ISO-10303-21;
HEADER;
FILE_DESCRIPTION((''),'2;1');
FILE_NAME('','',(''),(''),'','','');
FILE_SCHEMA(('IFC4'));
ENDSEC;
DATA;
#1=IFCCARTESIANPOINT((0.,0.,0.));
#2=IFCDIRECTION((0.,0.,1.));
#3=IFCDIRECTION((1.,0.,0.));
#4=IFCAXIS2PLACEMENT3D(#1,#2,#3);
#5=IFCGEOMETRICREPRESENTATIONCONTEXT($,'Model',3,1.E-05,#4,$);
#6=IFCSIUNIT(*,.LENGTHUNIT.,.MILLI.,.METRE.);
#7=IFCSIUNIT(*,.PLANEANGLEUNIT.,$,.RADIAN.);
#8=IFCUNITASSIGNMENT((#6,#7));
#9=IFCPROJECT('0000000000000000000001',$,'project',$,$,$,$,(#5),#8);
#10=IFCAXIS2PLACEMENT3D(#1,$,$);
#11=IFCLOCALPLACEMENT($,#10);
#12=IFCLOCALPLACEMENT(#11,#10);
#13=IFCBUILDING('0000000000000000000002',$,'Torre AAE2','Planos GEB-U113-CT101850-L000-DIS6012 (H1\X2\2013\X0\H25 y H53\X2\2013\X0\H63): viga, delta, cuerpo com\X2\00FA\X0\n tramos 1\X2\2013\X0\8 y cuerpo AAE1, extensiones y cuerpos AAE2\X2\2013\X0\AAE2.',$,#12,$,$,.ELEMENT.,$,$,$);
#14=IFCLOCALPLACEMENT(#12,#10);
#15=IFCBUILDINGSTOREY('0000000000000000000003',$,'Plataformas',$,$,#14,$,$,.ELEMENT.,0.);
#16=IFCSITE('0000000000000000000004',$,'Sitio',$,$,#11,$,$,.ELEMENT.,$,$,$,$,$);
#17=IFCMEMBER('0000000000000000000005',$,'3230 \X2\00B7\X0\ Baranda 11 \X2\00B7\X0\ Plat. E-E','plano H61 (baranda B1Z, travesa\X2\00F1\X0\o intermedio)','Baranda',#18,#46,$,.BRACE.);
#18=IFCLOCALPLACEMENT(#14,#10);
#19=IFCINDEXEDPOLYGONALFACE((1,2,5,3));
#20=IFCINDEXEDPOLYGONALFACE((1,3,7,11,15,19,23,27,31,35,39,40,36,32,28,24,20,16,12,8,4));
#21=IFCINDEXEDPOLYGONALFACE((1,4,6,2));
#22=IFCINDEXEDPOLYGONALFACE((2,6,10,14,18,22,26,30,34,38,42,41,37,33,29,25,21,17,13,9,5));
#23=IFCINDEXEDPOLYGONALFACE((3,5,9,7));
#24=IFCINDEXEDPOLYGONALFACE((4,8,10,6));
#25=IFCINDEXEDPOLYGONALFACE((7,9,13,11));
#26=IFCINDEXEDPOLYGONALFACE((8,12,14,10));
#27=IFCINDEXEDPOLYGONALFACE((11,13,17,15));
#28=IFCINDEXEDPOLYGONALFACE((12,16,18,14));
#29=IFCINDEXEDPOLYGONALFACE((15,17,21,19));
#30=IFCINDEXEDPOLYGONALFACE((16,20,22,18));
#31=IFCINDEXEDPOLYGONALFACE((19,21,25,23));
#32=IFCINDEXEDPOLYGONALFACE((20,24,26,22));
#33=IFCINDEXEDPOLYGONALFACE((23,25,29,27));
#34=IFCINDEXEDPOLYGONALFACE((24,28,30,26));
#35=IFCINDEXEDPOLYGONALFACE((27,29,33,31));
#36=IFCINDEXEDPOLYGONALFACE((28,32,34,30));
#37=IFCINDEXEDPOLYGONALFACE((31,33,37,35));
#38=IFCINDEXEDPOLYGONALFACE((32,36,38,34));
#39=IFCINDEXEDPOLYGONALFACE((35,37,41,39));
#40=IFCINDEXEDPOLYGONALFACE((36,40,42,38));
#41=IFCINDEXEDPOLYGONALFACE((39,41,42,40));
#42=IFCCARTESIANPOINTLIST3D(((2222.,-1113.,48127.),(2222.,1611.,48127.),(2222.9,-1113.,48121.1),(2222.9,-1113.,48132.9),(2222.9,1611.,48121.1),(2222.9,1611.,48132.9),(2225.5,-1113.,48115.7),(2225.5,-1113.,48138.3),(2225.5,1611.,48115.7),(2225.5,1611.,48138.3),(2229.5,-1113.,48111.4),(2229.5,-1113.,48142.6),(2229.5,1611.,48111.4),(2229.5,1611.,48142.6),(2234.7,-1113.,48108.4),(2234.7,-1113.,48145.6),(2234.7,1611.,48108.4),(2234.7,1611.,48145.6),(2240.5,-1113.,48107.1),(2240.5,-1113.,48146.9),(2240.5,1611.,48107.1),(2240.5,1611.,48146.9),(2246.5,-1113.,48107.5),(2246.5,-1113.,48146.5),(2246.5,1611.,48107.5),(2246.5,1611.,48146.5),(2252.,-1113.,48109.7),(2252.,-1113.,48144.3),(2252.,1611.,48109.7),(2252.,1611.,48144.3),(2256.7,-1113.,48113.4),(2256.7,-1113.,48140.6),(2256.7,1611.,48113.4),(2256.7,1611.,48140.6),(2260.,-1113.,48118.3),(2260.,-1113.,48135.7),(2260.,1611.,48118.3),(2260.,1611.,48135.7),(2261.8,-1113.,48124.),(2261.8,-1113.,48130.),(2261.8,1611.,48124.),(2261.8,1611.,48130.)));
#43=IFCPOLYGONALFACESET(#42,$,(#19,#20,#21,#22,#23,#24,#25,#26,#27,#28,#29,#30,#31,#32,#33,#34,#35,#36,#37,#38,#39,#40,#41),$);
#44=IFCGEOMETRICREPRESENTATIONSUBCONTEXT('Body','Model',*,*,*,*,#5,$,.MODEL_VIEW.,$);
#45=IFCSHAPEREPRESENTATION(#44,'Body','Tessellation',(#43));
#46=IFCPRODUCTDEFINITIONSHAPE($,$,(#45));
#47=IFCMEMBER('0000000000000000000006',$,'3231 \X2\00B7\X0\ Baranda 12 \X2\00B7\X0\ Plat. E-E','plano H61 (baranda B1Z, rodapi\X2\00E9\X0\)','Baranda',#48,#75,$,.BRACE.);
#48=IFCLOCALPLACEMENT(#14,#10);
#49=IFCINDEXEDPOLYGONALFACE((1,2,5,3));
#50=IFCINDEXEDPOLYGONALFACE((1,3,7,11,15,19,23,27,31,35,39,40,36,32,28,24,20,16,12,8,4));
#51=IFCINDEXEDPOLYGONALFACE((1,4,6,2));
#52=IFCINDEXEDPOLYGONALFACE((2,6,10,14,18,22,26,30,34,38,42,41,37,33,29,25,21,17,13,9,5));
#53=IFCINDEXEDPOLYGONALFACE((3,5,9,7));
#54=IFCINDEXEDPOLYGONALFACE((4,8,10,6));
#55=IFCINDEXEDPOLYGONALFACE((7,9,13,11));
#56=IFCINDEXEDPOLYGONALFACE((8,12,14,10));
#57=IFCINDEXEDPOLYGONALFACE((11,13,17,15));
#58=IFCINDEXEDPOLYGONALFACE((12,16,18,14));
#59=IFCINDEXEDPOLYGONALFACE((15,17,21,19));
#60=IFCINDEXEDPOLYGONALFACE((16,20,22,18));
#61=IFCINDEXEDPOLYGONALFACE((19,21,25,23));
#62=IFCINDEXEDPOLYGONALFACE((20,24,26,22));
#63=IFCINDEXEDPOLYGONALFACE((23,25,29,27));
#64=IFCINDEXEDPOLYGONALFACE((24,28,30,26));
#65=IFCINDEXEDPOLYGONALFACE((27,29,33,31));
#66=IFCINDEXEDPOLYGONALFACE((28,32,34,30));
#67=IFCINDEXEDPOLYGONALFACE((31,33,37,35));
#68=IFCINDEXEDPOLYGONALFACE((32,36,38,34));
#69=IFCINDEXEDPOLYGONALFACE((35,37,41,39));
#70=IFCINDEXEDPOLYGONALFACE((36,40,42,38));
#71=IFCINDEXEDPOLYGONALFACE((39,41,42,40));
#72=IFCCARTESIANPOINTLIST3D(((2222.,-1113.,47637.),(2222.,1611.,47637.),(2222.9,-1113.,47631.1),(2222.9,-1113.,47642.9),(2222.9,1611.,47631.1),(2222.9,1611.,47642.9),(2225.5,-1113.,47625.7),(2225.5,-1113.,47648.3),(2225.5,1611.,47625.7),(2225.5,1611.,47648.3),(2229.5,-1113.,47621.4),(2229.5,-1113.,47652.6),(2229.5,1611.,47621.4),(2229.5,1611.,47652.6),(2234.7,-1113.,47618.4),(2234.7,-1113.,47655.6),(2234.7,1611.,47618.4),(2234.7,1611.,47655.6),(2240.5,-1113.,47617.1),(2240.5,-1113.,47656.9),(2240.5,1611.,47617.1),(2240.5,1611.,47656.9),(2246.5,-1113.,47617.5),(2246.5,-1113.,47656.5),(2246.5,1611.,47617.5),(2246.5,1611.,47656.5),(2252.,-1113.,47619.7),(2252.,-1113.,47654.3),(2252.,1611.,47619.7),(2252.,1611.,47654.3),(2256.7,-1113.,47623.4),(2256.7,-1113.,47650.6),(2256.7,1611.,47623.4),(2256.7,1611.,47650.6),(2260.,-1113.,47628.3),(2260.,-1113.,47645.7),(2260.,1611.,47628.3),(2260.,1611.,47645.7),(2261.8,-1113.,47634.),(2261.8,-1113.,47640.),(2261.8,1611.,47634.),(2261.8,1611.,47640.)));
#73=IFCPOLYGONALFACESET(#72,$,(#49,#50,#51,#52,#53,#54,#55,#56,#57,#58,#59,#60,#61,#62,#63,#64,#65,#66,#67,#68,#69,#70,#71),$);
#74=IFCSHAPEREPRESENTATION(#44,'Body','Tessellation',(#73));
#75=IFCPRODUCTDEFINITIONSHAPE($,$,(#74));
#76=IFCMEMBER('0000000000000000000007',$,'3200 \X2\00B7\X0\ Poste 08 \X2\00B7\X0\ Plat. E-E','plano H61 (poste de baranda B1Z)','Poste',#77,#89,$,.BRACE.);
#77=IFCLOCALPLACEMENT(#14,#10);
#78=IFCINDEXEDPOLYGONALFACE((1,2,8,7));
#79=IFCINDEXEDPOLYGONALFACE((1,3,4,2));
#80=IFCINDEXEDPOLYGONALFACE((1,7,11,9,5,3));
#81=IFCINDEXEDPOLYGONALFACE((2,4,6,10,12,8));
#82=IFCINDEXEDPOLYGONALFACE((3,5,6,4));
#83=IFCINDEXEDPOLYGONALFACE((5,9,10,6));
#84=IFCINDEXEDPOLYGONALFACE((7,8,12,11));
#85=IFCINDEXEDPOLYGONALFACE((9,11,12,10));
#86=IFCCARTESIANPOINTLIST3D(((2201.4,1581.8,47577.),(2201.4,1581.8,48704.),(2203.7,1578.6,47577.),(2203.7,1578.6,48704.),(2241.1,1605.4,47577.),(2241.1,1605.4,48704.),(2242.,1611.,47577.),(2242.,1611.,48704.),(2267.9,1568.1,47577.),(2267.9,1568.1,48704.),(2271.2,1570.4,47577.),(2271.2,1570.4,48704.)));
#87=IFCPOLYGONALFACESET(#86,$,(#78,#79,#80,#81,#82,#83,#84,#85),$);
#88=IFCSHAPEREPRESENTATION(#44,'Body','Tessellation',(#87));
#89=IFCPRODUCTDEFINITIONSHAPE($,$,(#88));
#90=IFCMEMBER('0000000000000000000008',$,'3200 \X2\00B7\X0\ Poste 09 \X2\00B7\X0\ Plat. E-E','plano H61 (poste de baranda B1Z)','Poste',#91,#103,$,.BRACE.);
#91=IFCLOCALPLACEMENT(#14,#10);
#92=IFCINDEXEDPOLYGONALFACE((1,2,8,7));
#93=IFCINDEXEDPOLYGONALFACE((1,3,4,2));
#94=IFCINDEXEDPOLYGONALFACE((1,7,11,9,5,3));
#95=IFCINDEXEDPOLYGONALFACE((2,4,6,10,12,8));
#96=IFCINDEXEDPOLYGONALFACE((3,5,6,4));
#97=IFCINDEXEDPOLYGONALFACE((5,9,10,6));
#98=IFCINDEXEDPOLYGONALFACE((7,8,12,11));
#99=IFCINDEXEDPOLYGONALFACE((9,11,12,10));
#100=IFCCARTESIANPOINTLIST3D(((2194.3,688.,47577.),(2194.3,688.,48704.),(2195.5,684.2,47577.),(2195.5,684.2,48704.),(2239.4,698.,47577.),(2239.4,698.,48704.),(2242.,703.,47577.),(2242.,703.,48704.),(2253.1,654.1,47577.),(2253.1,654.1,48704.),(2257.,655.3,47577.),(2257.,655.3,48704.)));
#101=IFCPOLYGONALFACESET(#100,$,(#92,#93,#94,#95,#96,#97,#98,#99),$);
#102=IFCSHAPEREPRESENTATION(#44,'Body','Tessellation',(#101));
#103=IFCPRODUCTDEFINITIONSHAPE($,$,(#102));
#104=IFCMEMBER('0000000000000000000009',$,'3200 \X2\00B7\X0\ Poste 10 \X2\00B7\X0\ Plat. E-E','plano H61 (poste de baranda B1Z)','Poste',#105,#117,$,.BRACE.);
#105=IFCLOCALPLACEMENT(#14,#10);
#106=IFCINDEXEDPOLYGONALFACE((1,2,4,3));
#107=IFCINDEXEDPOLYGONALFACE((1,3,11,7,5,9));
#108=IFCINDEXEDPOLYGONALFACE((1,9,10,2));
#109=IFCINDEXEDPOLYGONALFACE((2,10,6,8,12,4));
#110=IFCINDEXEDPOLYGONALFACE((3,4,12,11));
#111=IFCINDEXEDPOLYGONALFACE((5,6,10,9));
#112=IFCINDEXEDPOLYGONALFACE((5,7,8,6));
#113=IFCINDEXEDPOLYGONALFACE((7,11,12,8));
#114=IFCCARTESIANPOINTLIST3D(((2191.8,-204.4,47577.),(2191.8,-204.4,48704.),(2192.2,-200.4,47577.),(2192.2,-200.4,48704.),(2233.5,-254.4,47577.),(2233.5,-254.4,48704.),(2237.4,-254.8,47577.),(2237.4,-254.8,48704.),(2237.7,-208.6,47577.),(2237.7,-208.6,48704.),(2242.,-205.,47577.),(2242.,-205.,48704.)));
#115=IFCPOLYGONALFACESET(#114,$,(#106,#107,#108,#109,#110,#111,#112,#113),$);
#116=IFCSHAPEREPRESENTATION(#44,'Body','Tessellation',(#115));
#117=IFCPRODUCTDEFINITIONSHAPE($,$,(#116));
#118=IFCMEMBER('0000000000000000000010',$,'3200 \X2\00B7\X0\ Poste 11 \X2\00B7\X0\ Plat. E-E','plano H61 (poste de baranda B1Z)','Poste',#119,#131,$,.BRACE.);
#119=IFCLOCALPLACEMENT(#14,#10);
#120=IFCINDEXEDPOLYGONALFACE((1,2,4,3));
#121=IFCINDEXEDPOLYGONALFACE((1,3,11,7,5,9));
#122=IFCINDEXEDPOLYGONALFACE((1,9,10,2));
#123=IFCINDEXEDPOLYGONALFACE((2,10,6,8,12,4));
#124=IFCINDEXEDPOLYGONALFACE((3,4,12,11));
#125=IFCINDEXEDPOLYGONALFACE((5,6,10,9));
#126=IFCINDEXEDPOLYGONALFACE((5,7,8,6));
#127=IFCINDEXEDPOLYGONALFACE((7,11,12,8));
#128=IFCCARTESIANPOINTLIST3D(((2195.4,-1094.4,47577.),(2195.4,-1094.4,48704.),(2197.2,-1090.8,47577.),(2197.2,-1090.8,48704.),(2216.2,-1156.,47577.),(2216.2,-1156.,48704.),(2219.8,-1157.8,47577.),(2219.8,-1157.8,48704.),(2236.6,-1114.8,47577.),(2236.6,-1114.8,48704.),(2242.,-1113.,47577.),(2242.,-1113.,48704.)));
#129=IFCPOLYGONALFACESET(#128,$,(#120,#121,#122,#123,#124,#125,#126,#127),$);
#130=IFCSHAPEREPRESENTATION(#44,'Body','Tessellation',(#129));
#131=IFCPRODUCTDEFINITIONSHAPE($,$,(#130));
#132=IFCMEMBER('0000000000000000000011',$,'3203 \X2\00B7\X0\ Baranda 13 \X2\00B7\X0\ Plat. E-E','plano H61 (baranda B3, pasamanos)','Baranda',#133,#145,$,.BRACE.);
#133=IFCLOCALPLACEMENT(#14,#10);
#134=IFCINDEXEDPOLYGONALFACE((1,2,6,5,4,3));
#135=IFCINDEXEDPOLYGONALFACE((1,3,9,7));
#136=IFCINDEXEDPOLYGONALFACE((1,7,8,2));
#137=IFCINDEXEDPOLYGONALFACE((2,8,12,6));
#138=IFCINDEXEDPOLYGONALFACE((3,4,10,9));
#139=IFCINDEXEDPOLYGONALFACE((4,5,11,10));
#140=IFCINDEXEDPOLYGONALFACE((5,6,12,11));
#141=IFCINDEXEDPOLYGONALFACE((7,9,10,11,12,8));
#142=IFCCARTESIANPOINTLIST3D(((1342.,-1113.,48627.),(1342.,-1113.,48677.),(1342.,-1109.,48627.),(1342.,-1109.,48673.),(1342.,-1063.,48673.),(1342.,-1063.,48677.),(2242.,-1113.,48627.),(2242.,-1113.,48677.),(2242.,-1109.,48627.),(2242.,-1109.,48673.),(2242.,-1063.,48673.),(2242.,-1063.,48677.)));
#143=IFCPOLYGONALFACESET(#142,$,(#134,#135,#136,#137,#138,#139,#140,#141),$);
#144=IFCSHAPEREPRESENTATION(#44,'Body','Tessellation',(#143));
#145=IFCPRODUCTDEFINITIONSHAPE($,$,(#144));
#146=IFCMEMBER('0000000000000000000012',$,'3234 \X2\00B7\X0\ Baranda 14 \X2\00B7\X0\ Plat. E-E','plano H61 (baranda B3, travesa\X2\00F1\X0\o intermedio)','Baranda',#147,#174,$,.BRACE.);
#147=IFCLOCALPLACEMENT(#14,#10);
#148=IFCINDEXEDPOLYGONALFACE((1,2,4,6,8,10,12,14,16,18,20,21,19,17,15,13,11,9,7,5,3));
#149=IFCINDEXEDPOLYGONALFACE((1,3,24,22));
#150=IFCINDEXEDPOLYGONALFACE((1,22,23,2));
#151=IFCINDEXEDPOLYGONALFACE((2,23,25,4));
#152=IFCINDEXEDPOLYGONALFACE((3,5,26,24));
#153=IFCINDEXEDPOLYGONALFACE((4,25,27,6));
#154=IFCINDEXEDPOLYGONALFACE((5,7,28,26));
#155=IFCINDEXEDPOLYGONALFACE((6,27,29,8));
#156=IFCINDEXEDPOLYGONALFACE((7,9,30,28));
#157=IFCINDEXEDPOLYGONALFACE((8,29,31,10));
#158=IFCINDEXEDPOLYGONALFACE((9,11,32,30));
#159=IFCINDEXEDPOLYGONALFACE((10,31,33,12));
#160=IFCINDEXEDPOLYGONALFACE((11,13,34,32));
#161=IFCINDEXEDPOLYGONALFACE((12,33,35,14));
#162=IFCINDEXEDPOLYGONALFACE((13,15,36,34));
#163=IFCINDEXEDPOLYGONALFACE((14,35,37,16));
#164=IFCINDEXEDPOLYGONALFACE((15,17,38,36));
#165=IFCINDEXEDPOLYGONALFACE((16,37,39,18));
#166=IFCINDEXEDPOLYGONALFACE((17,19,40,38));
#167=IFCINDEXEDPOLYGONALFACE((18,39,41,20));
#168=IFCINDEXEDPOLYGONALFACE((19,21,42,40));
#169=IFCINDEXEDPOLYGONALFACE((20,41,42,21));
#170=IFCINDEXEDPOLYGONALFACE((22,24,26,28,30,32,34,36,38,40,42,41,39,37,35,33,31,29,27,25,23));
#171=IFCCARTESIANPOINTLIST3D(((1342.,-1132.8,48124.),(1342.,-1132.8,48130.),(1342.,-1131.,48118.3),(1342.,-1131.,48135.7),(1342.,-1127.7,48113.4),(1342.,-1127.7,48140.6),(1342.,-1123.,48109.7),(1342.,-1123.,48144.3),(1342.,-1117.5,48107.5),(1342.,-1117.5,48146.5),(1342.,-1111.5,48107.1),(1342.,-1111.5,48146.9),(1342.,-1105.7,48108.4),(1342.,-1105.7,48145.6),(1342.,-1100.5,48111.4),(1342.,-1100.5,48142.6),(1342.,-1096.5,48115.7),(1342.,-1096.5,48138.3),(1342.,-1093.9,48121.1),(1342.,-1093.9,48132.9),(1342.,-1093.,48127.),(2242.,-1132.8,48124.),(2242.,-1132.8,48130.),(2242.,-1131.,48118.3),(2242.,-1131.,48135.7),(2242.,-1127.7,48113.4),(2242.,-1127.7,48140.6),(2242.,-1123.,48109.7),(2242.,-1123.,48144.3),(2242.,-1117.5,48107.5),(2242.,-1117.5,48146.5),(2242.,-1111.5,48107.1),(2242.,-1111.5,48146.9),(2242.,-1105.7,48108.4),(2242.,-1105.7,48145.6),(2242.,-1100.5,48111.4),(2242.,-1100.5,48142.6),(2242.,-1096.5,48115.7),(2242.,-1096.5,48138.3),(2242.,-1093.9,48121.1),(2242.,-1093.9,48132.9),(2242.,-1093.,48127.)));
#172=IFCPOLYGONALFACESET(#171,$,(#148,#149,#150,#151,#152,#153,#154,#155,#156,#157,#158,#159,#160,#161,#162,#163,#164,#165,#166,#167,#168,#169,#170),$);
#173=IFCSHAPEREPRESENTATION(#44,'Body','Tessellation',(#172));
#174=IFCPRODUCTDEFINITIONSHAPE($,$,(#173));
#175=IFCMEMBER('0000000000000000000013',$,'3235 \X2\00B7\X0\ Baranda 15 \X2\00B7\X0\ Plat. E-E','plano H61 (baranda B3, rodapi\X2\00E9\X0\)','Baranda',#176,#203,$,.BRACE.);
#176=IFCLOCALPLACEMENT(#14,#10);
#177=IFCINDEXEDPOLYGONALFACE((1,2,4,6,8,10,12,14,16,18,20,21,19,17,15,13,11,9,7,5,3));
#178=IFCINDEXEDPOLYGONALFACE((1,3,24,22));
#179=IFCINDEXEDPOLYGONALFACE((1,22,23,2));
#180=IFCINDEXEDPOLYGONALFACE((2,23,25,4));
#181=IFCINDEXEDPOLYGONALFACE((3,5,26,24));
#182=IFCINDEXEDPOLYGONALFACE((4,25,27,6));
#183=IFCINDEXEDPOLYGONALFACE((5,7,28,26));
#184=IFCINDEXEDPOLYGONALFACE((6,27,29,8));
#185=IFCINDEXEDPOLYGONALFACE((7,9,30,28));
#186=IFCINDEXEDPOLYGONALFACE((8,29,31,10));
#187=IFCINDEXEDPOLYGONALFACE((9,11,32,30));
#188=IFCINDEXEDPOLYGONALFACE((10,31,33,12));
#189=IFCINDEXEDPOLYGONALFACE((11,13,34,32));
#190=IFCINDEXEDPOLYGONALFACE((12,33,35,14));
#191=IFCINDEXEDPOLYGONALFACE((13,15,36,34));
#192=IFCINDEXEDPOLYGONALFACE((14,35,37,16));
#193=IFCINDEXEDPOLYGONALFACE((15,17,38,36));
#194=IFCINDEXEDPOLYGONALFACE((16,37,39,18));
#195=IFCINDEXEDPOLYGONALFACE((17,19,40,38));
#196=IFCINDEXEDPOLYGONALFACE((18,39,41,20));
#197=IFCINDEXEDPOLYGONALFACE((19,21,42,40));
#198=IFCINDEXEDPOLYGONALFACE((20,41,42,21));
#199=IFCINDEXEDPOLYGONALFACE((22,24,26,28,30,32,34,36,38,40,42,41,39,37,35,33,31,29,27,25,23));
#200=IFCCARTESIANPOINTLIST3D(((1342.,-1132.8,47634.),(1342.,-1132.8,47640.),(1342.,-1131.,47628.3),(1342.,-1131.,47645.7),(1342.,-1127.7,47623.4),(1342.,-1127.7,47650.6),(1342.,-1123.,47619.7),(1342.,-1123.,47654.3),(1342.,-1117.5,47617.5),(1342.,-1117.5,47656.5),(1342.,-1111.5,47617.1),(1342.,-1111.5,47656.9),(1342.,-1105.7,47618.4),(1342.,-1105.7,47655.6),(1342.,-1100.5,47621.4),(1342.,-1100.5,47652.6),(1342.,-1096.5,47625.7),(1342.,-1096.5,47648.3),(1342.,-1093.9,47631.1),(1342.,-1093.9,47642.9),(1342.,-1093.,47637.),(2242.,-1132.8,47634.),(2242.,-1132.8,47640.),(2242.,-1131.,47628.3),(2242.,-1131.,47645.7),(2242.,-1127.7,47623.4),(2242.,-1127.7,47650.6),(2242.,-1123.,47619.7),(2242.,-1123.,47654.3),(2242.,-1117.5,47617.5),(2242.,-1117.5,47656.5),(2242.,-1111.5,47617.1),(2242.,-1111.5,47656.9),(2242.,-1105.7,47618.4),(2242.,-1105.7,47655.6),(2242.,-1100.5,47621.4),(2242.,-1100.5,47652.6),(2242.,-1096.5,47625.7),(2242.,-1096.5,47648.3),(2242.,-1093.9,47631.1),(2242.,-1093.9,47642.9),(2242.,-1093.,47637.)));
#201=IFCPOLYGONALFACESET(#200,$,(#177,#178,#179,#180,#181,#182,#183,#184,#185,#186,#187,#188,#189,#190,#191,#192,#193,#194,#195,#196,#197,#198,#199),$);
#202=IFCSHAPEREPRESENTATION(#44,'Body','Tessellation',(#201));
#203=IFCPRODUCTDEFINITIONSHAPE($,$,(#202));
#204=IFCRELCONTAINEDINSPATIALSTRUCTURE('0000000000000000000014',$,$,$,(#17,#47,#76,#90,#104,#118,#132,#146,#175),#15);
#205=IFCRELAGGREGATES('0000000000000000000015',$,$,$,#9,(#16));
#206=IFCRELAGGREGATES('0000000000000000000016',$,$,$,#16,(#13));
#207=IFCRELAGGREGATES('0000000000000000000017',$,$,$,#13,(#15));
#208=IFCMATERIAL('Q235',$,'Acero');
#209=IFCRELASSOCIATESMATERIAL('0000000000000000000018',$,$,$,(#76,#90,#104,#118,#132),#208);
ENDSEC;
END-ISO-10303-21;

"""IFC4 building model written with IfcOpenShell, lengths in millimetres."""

from ifc_helpers import new_model, si_unit, frame, frame_2d, origin, origin_with_axes, place, context, subcontext, project, spatial, circle, l_section, extrude, material, element, save


model = new_model("IFC4")

# Units and contexts
model_context = context("Model", 3, precision=1e-05, world=origin_with_axes())
body_context = subcontext(model_context, "Body", "Model", "MODEL_VIEW")
ifc_project = project(units=[si_unit("LENGTHUNIT", "METRE", prefix="MILLI"), si_unit("PLANEANGLEUNIT", "RADIAN")], contexts=[model_context])

# Site, building, storey
site_placement = place(None, origin())
site = spatial("IfcSite", under=ifc_project, at=site_placement, Name="Sitio", CompositionType="ELEMENT")
building_placement = place(site_placement, origin())
building = spatial("IfcBuilding", under=site, at=building_placement, Name="Torre AAE2", Description="Planos GEB-U113-CT101850-L000-DIS6012 (H1–H25 y H53–H63): viga, delta, cuerpo común tramos 1–8 y cuerpo AAE1, extensiones y cuerpos AAE2–AAE2.", CompositionType="ELEMENT")
storey_placement = place(building_placement, origin())
storey = spatial("IfcBuildingStorey", under=building, at=storey_placement, Name="Plataformas", CompositionType="ELEMENT", Elevation=0.0)

# Members
ifc_material = material(Name="Q235", Category="Acero")
for number, where, z_axis, x_axis, name, description in (
    (1, (2242.0, 1611.0, 48127.0), (0.0, -1.0, 0.0), (-1.0, 0.0, 0.0), "3230 · Baranda 11 · Plat. E-E", "plano H61 (baranda B1Z, travesaño intermedio)"),
    (2, (2242.0, 1611.0, 47637.0), (0.0, -1.0, 0.0), (-1.0, 0.0, 0.0), "3231 · Baranda 12 · Plat. E-E", "plano H61 (baranda B1Z, rodapié)"),
):
    element("IfcMember", number, at=place(storey_placement, frame(where, z_axis=z_axis, x_axis=x_axis)), inside=storey, Name=name, Description=description, ObjectType="Baranda", PredefinedType="BRACE", context=body_context, shape_type="SweptSolid", body=[
        extrude(circle(Radius=20.0), None, (0.0, 0.0, 1.0), 2724.0),
    ])
for number, where, z_axis, x_axis, name in (
    (3, (2242.0, 1611.0, 47577.0), (0.0, 0.0, 1.0), (-0.81209, -0.583532, 0.0), "3200 · Poste 08 · Plat. E-E"),
    (4, (2242.0, 703.0, 47577.0), (0.0, 0.0, 1.0), (-0.954192, -0.299196, 0.0), "3200 · Poste 09 · Plat. E-E"),
    (5, (2242.0, -205.0, 47577.0), (0.0, 0.0, 1.0), (-0.995846, 0.091056, 0.0), "3200 · Poste 10 · Plat. E-E"),
    (6, (2242.0, -1113.0, 47577.0), (0.0, 0.0, 1.0), (-0.895702, 0.444655, 0.0), "3200 · Poste 11 · Plat. E-E"),
):
    element("IfcMember", number, at=place(storey_placement, frame(where, z_axis=z_axis, x_axis=x_axis)), inside=storey, material=ifc_material, Name=name, Description="plano H61 (poste de baranda B1Z)", ObjectType="Poste", PredefinedType="BRACE", context=body_context, shape_type="SweptSolid", body=[
        extrude(l_section(Depth=50.0, Width=50.0, Thickness=4.0, at=frame_2d((25.0, 25.0))), None, (0.0, 0.0, 1.0), 1127.0),
    ])
member_1_placement = place(storey_placement, frame((2242.0, -1113.0, 48677.0), z_axis=(-1.0, 0.0, 0.0), x_axis=(0.0, 1.0, 0.0)))
element("IfcMember", 7, at=member_1_placement, inside=storey, material=ifc_material, Name="3203 · Baranda 13 · Plat. E-E", Description="plano H61 (baranda B3, pasamanos)", ObjectType="Baranda", PredefinedType="BRACE", context=body_context, shape_type="SweptSolid", body=[
    extrude(l_section(Depth=50.0, Width=50.0, Thickness=4.0, at=frame_2d((25.0, 25.0))), None, (0.0, 0.0, 1.0), 900.0),
])
for number, where, z_axis, x_axis, name, description in (
    (8, (2242.0, -1113.0, 48127.0), (-1.0, 0.0, 0.0), (0.0, 1.0, 0.0), "3234 · Baranda 14 · Plat. E-E", "plano H61 (baranda B3, travesaño intermedio)"),
    (9, (2242.0, -1113.0, 47637.0), (-1.0, 0.0, 0.0), (0.0, 1.0, 0.0), "3235 · Baranda 15 · Plat. E-E", "plano H61 (baranda B3, rodapié)"),
):
    element("IfcMember", number, at=place(storey_placement, frame(where, z_axis=z_axis, x_axis=x_axis)), inside=storey, Name=name, Description=description, ObjectType="Baranda", PredefinedType="BRACE", context=body_context, shape_type="SweptSolid", body=[
        extrude(circle(Radius=20.0), None, (0.0, 0.0, 1.0), 900.0),
    ])

save(model, "model.ifc")
